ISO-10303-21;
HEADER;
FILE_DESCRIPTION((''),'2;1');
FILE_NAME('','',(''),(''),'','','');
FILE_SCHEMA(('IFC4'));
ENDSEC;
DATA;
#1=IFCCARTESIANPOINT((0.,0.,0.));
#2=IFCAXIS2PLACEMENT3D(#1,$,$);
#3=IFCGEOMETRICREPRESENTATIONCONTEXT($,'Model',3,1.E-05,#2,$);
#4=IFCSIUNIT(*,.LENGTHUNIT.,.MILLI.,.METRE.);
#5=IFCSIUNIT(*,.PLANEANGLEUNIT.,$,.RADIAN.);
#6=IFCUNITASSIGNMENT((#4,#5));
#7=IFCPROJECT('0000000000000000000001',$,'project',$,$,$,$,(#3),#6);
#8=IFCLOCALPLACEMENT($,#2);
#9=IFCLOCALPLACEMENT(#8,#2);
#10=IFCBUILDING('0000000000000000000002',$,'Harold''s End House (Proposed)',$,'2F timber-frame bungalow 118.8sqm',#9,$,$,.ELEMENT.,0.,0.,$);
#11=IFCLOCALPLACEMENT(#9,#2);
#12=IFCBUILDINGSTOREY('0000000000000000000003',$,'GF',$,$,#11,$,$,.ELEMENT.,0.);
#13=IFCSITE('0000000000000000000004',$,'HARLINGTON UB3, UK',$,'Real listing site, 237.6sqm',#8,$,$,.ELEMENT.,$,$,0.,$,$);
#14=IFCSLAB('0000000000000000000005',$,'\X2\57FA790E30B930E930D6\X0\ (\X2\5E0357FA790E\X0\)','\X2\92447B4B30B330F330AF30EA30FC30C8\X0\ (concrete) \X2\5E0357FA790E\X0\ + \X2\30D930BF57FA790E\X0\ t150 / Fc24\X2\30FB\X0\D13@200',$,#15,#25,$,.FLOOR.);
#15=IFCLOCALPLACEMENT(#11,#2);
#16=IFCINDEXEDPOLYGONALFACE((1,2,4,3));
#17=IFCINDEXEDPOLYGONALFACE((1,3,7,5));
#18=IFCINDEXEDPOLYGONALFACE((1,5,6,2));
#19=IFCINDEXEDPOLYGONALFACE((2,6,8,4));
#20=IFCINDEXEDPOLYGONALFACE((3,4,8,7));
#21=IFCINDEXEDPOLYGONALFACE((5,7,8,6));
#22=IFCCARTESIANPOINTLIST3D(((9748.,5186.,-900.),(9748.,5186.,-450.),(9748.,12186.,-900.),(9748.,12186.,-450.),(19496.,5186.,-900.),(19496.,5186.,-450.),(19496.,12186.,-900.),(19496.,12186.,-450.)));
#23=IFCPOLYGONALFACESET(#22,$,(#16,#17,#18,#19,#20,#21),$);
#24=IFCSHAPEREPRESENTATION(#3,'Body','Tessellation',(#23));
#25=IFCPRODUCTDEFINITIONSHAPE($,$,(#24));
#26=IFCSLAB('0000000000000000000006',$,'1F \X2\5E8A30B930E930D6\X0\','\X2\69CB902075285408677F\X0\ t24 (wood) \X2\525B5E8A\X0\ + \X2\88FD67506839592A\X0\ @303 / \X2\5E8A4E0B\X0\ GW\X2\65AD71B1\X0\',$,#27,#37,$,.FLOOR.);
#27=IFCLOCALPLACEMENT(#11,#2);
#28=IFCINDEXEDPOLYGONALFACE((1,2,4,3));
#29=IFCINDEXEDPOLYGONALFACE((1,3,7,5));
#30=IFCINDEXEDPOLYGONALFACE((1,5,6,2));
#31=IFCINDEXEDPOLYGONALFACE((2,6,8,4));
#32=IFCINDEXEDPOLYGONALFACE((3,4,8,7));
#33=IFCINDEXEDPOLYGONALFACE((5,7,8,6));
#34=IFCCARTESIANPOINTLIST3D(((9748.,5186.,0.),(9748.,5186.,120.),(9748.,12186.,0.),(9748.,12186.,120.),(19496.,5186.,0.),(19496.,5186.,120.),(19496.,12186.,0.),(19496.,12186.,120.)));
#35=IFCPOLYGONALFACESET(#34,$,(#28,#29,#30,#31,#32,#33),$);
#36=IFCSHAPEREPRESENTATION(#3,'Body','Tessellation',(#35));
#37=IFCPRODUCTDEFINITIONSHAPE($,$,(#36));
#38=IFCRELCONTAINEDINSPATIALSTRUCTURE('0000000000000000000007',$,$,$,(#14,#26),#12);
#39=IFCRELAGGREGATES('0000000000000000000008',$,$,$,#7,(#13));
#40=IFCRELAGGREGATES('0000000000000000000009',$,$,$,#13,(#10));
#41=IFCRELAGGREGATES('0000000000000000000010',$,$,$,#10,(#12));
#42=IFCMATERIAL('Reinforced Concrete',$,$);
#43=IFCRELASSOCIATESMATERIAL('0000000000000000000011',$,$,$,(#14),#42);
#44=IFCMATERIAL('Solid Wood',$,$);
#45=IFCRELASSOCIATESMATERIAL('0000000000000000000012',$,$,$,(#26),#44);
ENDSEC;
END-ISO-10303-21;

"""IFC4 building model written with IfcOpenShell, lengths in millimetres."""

from ifc_helpers import new_model, si_unit, frame, frame_2d, origin, place, context, project, spatial, rectangle, extrude, material, element, save


model = new_model("IFC4")

# Units and contexts
model_context = context("Model", 3, precision=1e-05, world=origin())
ifc_project = project(units=[si_unit("LENGTHUNIT", "METRE", prefix="MILLI"), si_unit("PLANEANGLEUNIT", "RADIAN")], contexts=[model_context])

# Site, building, storey
site_placement = place(None, origin())
site = spatial("IfcSite", under=ifc_project, at=site_placement, Name="HARLINGTON UB3, UK", ObjectType="Real listing site, 237.6sqm", CompositionType="ELEMENT", RefElevation=0.0)
building_placement = place(site_placement, origin())
building = spatial("IfcBuilding", under=site, at=building_placement, Name="Harold's End House (Proposed)", ObjectType="2F timber-frame bungalow 118.8sqm", CompositionType="ELEMENT", ElevationOfRefHeight=0.0, ElevationOfTerrain=0.0)
storey_placement = place(building_placement, origin())
storey = spatial("IfcBuildingStorey", under=building, at=storey_placement, Name="GF", CompositionType="ELEMENT", Elevation=0.0)

# Slabs
ifc_material_1 = material(Name="Reinforced Concrete")
slab_1_placement = place(storey_placement, frame((4874.0, 2593.0, -450.0)))
element("IfcSlab", 1, at=slab_1_placement, inside=storey, material=ifc_material_1, Name="基礎スラブ (布基礎)", Description="鉄筋コンクリート (concrete) 布基礎 + ベタ基礎 t150 / Fc24・D13@200", PredefinedType="FLOOR", context=model_context, shape_type="SweptSolid", body=[
    extrude(rectangle(XDim=9748.0, YDim=7000.0, at=frame_2d((4874.0, 3500.0))), frame((4874.0, 2593.0, -450.0)), (0.0, 0.0, 1.0), 450.0),
])
ifc_material_2 = material(Name="Solid Wood")
slab_2_placement = place(storey_placement, frame((4874.0, 2593.0, 0.0)))
element("IfcSlab", 2, at=slab_2_placement, inside=storey, material=ifc_material_2, Name="1F 床スラブ", Description="構造用合板 t24 (wood) 剛床 + 製材根太 @303 / 床下 GW断熱", PredefinedType="FLOOR", context=model_context, shape_type="SweptSolid", body=[
    extrude(rectangle(XDim=9748.0, YDim=7000.0, at=frame_2d((4874.0, 3500.0))), frame((4874.0, 2593.0, 0.0)), (0.0, 0.0, 1.0), 120.0),
])

save(model, "model.ifc")
